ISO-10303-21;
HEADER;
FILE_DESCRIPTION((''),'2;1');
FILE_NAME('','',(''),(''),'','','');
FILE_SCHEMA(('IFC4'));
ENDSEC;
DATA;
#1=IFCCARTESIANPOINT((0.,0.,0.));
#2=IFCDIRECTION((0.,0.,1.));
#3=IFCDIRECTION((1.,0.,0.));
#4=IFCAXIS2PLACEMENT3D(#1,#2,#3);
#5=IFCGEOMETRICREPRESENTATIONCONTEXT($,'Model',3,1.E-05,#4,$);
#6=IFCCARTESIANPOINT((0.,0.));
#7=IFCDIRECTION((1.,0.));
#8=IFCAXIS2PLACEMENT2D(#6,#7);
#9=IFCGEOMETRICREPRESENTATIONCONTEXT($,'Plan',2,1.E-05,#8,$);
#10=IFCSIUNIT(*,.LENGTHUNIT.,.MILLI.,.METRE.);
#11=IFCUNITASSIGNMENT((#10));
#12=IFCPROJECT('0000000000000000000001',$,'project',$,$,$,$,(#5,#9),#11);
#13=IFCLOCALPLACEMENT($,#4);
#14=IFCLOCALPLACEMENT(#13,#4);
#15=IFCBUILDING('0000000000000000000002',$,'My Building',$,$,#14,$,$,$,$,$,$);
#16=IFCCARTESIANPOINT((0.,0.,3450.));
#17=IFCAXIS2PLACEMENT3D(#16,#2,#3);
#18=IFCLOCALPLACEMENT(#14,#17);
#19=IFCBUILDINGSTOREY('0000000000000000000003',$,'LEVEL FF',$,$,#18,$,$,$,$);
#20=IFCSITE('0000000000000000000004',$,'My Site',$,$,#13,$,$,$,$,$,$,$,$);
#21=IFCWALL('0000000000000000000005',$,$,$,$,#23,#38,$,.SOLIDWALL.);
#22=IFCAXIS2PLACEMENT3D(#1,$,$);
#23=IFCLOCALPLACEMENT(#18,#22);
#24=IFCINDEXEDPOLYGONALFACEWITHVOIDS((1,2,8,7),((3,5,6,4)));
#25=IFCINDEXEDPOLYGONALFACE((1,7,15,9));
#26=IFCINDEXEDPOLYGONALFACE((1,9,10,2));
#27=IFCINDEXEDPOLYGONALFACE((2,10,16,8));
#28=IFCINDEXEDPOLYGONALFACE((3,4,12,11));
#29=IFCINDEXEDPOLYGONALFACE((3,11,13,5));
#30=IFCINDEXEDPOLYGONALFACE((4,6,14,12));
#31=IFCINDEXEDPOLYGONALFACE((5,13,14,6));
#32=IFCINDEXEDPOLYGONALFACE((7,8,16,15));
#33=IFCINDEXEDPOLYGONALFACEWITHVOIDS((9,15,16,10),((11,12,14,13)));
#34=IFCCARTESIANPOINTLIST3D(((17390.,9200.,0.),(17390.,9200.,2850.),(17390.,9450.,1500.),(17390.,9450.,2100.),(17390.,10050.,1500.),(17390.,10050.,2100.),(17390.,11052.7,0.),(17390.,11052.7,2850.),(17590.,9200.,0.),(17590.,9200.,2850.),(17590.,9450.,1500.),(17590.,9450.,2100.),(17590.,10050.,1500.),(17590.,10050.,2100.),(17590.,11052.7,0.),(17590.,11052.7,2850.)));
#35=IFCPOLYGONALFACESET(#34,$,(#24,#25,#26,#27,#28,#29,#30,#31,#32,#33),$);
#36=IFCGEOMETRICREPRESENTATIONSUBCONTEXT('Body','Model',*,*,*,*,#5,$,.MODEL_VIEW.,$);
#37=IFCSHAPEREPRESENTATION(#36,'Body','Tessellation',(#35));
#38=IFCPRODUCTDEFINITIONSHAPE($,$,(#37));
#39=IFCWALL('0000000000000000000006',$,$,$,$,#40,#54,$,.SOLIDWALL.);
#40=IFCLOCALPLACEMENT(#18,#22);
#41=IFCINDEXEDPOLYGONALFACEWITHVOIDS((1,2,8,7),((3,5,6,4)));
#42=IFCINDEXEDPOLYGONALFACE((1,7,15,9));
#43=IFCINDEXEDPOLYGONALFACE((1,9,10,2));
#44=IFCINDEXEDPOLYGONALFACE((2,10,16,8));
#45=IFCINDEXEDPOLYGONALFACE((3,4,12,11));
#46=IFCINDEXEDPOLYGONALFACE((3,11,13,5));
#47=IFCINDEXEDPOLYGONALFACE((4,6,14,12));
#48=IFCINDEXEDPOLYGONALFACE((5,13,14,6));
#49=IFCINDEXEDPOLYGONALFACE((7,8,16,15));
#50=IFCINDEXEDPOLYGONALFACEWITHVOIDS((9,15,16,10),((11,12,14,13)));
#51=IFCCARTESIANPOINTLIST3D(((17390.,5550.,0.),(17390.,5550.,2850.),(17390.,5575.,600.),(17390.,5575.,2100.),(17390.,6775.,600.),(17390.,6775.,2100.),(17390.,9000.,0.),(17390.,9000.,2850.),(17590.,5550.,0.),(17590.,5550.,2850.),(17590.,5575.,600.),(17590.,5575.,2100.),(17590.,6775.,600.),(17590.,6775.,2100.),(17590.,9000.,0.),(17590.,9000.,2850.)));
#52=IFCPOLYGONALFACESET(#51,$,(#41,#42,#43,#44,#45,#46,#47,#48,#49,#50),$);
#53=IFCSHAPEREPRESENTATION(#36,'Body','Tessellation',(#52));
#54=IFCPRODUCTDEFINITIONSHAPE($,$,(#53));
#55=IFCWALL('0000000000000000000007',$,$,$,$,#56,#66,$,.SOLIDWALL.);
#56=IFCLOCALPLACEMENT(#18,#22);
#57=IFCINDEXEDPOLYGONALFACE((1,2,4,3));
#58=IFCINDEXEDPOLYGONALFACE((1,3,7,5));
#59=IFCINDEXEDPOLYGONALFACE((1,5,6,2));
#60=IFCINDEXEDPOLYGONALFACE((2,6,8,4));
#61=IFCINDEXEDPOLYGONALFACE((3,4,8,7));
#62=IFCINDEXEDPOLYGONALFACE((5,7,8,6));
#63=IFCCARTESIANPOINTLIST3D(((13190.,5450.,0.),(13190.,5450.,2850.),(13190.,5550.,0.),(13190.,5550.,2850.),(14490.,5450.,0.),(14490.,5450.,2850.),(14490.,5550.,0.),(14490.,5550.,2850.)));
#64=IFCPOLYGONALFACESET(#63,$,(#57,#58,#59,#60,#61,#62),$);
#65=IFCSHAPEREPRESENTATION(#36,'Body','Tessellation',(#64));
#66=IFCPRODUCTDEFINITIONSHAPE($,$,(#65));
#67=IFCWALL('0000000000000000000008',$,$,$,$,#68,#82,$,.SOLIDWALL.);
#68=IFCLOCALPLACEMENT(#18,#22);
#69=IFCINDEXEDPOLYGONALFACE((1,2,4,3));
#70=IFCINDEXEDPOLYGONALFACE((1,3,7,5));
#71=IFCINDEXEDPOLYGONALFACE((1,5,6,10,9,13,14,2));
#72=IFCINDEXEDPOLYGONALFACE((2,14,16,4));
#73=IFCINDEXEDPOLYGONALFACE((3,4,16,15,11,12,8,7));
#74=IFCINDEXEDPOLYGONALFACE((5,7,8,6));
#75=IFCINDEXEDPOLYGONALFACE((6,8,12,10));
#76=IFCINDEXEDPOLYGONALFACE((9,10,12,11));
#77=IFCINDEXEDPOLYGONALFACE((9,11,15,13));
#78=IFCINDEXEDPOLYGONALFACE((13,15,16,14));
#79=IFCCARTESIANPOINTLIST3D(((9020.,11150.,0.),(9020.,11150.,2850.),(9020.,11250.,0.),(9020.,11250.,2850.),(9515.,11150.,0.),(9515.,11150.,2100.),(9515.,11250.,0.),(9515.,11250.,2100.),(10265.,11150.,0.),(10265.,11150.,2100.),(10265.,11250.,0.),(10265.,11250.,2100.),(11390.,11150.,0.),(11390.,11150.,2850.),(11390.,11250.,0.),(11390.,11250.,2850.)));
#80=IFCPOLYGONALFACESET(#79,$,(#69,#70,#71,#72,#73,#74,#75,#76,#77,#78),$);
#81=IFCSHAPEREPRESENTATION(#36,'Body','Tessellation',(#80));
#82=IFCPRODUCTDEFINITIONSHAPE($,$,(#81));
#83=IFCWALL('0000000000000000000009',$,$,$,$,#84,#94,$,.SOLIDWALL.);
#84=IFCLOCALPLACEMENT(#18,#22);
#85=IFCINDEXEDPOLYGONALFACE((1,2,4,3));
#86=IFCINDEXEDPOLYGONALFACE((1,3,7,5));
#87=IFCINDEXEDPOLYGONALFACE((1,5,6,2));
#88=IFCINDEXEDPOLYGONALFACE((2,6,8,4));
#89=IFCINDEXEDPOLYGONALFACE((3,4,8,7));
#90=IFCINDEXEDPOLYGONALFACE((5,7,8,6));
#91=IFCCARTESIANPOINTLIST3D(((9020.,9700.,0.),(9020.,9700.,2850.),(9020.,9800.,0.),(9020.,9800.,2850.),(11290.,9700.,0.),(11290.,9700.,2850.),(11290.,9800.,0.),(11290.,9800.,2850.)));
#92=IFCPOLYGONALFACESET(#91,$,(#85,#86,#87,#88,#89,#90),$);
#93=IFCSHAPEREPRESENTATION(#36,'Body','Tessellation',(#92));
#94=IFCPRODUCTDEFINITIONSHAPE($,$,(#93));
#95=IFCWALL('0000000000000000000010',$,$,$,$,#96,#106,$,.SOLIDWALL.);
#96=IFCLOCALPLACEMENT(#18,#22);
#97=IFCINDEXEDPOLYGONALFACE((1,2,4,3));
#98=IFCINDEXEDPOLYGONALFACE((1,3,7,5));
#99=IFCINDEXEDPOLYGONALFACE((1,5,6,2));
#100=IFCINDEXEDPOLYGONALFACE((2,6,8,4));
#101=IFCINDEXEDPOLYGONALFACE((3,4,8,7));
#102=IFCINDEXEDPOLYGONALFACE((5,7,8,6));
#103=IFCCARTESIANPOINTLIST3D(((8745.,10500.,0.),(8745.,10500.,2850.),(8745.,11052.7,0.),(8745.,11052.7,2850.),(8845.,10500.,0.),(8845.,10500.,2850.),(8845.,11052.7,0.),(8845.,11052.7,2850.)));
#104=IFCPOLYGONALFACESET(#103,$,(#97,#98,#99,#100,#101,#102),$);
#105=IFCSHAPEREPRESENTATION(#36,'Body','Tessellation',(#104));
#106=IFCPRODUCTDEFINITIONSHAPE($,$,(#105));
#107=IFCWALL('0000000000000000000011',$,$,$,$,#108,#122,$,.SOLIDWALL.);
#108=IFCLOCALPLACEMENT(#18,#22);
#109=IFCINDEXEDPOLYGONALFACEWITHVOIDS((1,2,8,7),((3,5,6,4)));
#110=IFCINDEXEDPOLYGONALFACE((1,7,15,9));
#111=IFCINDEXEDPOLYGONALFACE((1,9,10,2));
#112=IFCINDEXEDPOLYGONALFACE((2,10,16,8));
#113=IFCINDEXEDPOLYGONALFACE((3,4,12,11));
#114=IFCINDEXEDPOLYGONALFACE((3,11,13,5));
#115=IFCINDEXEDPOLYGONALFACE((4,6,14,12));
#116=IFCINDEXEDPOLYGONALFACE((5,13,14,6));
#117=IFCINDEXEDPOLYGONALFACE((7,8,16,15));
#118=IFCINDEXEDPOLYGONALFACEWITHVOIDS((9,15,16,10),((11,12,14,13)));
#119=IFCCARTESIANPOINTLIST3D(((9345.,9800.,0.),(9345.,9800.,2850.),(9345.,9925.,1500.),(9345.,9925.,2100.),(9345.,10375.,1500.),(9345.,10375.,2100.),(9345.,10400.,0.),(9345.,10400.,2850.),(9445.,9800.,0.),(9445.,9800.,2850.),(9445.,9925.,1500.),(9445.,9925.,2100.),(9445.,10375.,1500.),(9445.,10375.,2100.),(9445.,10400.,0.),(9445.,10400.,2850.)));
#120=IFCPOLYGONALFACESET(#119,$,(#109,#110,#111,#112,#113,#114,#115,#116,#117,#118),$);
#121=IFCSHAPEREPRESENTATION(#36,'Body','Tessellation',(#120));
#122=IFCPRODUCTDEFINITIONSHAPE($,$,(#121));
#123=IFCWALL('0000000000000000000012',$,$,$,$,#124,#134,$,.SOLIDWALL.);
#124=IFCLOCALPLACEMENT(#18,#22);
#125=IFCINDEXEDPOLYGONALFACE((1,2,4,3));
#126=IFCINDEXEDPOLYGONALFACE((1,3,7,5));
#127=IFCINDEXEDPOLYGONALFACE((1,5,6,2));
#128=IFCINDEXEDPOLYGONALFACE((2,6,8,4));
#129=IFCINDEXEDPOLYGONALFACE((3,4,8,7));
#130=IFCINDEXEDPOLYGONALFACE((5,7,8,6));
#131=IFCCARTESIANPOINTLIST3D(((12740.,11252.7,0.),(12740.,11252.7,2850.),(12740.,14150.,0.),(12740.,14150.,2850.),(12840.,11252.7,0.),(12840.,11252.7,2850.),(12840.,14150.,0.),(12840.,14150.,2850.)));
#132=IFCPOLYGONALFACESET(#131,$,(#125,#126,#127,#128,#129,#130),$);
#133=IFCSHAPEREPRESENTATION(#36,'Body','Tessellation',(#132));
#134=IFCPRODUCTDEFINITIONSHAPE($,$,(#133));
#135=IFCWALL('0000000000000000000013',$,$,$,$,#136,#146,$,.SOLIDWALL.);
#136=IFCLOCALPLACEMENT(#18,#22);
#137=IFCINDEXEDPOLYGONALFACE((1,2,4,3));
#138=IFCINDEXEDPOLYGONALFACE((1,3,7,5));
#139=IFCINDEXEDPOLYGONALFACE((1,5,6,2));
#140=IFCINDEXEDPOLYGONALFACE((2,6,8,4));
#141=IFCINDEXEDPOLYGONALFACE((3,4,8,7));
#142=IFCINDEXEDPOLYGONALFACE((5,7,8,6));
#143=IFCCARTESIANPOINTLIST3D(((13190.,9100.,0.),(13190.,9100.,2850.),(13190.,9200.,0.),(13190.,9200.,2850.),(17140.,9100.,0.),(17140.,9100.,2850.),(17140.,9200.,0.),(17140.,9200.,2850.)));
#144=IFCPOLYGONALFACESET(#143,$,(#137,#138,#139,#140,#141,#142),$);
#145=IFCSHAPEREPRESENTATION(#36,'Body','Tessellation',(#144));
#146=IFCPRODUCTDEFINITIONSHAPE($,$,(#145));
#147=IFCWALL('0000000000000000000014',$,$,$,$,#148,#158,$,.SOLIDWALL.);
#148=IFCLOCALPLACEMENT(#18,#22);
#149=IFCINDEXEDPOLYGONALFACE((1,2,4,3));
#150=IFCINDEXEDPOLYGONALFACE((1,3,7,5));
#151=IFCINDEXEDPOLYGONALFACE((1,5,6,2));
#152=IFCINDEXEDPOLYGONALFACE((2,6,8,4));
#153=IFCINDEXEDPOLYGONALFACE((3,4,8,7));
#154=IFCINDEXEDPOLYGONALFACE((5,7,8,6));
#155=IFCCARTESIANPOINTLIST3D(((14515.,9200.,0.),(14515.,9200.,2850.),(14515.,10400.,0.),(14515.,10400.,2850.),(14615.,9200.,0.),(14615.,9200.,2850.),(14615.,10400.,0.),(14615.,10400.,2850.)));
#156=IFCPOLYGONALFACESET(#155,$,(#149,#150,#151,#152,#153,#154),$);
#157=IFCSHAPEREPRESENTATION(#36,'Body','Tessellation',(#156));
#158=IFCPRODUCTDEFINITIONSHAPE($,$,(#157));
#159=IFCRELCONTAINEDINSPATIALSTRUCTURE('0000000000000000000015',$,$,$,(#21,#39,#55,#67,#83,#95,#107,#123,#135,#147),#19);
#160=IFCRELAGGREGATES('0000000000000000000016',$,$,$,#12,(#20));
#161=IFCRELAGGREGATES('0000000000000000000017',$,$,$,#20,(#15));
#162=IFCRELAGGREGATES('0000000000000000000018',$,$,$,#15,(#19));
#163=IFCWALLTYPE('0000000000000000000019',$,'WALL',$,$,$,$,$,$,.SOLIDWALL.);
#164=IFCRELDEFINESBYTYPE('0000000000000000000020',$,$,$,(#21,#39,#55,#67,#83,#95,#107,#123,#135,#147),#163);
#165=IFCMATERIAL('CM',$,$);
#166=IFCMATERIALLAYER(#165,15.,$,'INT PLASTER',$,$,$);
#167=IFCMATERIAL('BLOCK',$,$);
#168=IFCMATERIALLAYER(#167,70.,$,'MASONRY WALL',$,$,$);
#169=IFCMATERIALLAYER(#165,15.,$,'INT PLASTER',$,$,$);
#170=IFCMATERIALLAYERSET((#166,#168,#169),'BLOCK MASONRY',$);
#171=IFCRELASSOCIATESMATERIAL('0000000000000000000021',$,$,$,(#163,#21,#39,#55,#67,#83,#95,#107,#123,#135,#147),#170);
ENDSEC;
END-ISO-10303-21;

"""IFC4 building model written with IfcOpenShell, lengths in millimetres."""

from ifc_helpers import new_model, si_unit, frame, origin_with_axes, origin_2d_with_axis, place, context, subcontext, project, spatial, indexed_curve, outline, extrude, material, layer, layer_set, layer_usage, type_object, element, save


model = new_model("IFC4")

# Units and contexts
model_context = context("Model", 3, precision=1e-05, world=origin_with_axes())
plan_context = context("Plan", 2, precision=1e-05, world=origin_2d_with_axis())
body_context = subcontext(model_context, "Body", "Model", "MODEL_VIEW")
ifc_project = project(units=[si_unit("LENGTHUNIT", "METRE", prefix="MILLI")], contexts=[model_context, plan_context])

# Site, building, storey
site_placement = place(None, origin_with_axes())
site = spatial("IfcSite", under=ifc_project, at=site_placement, Name="My Site")
building_placement = place(site_placement, origin_with_axes())
building = spatial("IfcBuilding", under=site, at=building_placement, Name="My Building")
storey_placement = place(building_placement, frame((0.0, 0.0, 3450.0), z_axis=(0.0, 0.0, 1.0), x_axis=(1.0, 0.0, 0.0)))
storey = spatial("IfcBuildingStorey", under=building, at=storey_placement, Name="LEVEL FF")

# Shared definitions
ifc_material_1 = material(Name="CM")
ifc_layer_1 = layer(ifc_material_1, 15.0, Name="INT PLASTER")
ifc_material_2 = material(Name="BLOCK")
ifc_layer_2 = layer(ifc_material_2, 70.0, Name="MASONRY WALL")
ifc_layer_3 = layer(ifc_material_1, 15.0, Name="INT PLASTER")
ifc_layer_set = layer_set([ifc_layer_1, ifc_layer_2, ifc_layer_3], Name="BLOCK MASONRY")
wall_type = type_object("IfcWallType", Name="WALL", PredefinedType="SOLIDWALL", material=ifc_layer_set)

# Walls, openings
ifc_layer_usage_1 = layer_usage(ifc_layer_set, "AXIS2", "POSITIVE", 0.0)
wall_1_placement = place(storey_placement, frame((17590.0, 9200.0, 0.0), z_axis=(0.0, 0.0, 1.0), x_axis=(0.0, 1.0, 0.0)))
wall_1 = element("IfcWall", 1, at=wall_1_placement, inside=storey, type_object=wall_type, material=ifc_layer_usage_1, PredefinedType="SOLIDWALL", context=body_context, shape_type="SweptSolid", body=[
    extrude(outline(indexed_curve([(0.0, 0.0), (0.0, 200.0), (1852.7, 200.0), (1852.7, 0.0), (0.0, 0.0)], self_intersect=False)), origin_with_axes(), (0.0, 0.0, 1.0), 2850.0),
])
opening_1_placement = place(wall_1_placement, frame((850.0, 200.0, 1500.0), z_axis=(0.0, 0.0, 1.0), x_axis=(-1.0, 0.0, 0.0)))
element("IfcOpeningElement", 2, at=opening_1_placement, cuts=wall_1, PredefinedType="OPENING", context=body_context, shape_type="SweptSolid", body=[
    extrude(outline(indexed_curve([(0.0, 0.0), (0.0, 400.0), (600.0, 400.0), (600.0, 0.0), (0.0, 0.0)], self_intersect=False)), frame((0.0, -100.0, 0.0), z_axis=(0.0, 0.0, 1.0), x_axis=(1.0, 0.0, 0.0)), (0.0, 0.0, 1.0), 600.0),
])
ifc_layer_usage_2 = layer_usage(ifc_layer_set, "AXIS2", "POSITIVE", 0.0)
wall_2_placement = place(storey_placement, frame((17590.0, 5550.0, 0.0), z_axis=(0.0, 0.0, 1.0), x_axis=(0.0, 1.0, 0.0)))
wall_2 = element("IfcWall", 3, at=wall_2_placement, inside=storey, type_object=wall_type, material=ifc_layer_usage_2, PredefinedType="SOLIDWALL", context=body_context, shape_type="SweptSolid", body=[
    extrude(outline(indexed_curve([(0.0, 0.0), (0.0, 200.0), (3450.0, 200.0), (3450.0, 0.0), (0.0, 0.0)], self_intersect=False)), origin_with_axes(), (0.0, 0.0, 1.0), 2850.0),
])
opening_2_placement = place(wall_2_placement, frame((1225.0, 200.0, 600.0), z_axis=(0.0, 0.0, 1.0), x_axis=(-1.0, 0.0, 0.0)))
element("IfcOpeningElement", 4, at=opening_2_placement, cuts=wall_2, PredefinedType="OPENING", context=body_context, shape_type="SweptSolid", body=[
    extrude(outline(indexed_curve([(0.0, 0.0), (0.0, 400.0), (1200.0, 400.0), (1200.0, 0.0), (0.0, 0.0)], self_intersect=False)), frame((0.0, -100.0, 0.0), z_axis=(0.0, 0.0, 1.0), x_axis=(1.0, 0.0, 0.0)), (0.0, 0.0, 1.0), 1500.0),
])

# Wall
ifc_layer_usage_3 = layer_usage(ifc_layer_set, "AXIS2", "POSITIVE", 0.0)
wall_3_placement = place(storey_placement, frame((13190.0, 5550.0, 0.0), z_axis=(0.0, 0.0, 1.0), x_axis=(0.0, -1.0, 0.0)))
element("IfcWall", 5, at=wall_3_placement, inside=storey, type_object=wall_type, material=ifc_layer_usage_3, PredefinedType="SOLIDWALL", context=body_context, shape_type="SweptSolid", body=[
    extrude(outline(indexed_curve([(0.0, 0.0), (0.0, 1300.0), (100.0, 1300.0), (100.0, 0.0), (0.0, 0.0)], self_intersect=False)), origin_with_axes(), (0.0, 0.0, 1.0), 2850.0),
])

# Wall, opening
ifc_layer_usage_4 = layer_usage(ifc_layer_set, "AXIS2", "POSITIVE", 0.0)
wall_4_placement = place(storey_placement, frame((9020.0, 11250.0, 0.0), z_axis=(0.0, 0.0, 1.0), x_axis=(0.0, -1.0, 0.0)))
wall_4 = element("IfcWall", 6, at=wall_4_placement, inside=storey, type_object=wall_type, material=ifc_layer_usage_4, PredefinedType="SOLIDWALL", context=body_context, shape_type="SweptSolid", body=[
    extrude(outline(indexed_curve([(0.0, 0.0), (0.0, 2370.0), (100.0, 2370.0), (100.0, 0.0), (0.0, 0.0)], self_intersect=False)), origin_with_axes(), (0.0, 0.0, 1.0), 2850.0),
])
opening_3_placement = place(wall_4_placement, frame((0.0, 1245.0, 0.0), z_axis=(0.0, 0.0, 1.0), x_axis=(0.0, -1.0, 0.0)))
element("IfcOpeningElement", 7, at=opening_3_placement, cuts=wall_4, PredefinedType="OPENING", context=body_context, shape_type="SweptSolid", body=[
    extrude(outline(indexed_curve([(0.0, 0.0), (0.0, 400.0), (750.0, 400.0), (750.0, 0.0), (0.0, 0.0)], self_intersect=False)), frame((0.0, -100.0, 0.0), z_axis=(0.0, 0.0, 1.0), x_axis=(1.0, 0.0, 0.0)), (0.0, 0.0, 1.0), 2100.0),
])

# Wall
ifc_layer_usage_5 = layer_usage(ifc_layer_set, "AXIS2", "POSITIVE", 0.0)
wall_5_placement = place(storey_placement, frame((9020.0, 9800.0, 0.0), z_axis=(0.0, 0.0, 1.0), x_axis=(0.0, -1.0, 0.0)))
element("IfcWall", 8, at=wall_5_placement, inside=storey, type_object=wall_type, material=ifc_layer_usage_5, PredefinedType="SOLIDWALL", context=body_context, shape_type="SweptSolid", body=[
    extrude(outline(indexed_curve([(0.0, 0.0), (0.0, 2270.0), (100.0, 2270.0), (100.0, 0.0), (0.0, 0.0)], self_intersect=False)), origin_with_axes(), (0.0, 0.0, 1.0), 2850.0),
])

# Wall
ifc_layer_usage_6 = layer_usage(ifc_layer_set, "AXIS2", "POSITIVE", 0.0)
wall_6_placement = place(storey_placement, frame((8845.0, 10500.0, 0.0), z_axis=(0.0, 0.0, 1.0), x_axis=(0.0, 1.0, 0.0)))
element("IfcWall", 9, at=wall_6_placement, inside=storey, type_object=wall_type, material=ifc_layer_usage_6, PredefinedType="SOLIDWALL", context=body_context, shape_type="SweptSolid", body=[
    extrude(outline(indexed_curve([(0.0, 0.0), (0.0, 100.0), (552.7, 100.0), (552.7, 0.0), (0.0, 0.0)], self_intersect=False)), origin_with_axes(), (0.0, 0.0, 1.0), 2850.0),
])

# Wall, opening
ifc_layer_usage_7 = layer_usage(ifc_layer_set, "AXIS2", "POSITIVE", 0.0)
wall_7_placement = place(storey_placement, frame((9445.0, 9800.0, 0.0), z_axis=(0.0, 0.0, 1.0), x_axis=(0.0, 1.0, 0.0)))
wall_7 = element("IfcWall", 10, at=wall_7_placement, inside=storey, type_object=wall_type, material=ifc_layer_usage_7, PredefinedType="SOLIDWALL", context=body_context, shape_type="SweptSolid", body=[
    extrude(outline(indexed_curve([(0.0, 0.0), (0.0, 100.0), (600.0, 100.0), (600.0, 0.0), (0.0, 0.0)], self_intersect=False)), origin_with_axes(), (0.0, 0.0, 1.0), 2850.0),
])
opening_4_placement = place(wall_7_placement, frame((125.0, 0.0, 1500.0), z_axis=(0.0, 0.0, 1.0), x_axis=(1.0, 0.0, 0.0)))
element("IfcOpeningElement", 11, at=opening_4_placement, cuts=wall_7, PredefinedType="OPENING", context=body_context, shape_type="SweptSolid", body=[
    extrude(outline(indexed_curve([(0.0, 0.0), (0.0, 400.0), (450.0, 400.0), (450.0, 0.0), (0.0, 0.0)], self_intersect=False)), frame((0.0, -100.0, 0.0), z_axis=(0.0, 0.0, 1.0), x_axis=(1.0, 0.0, 0.0)), (0.0, 0.0, 1.0), 600.0),
])

# Walls
ifc_layer_usage_8 = layer_usage(ifc_layer_set, "AXIS2", "POSITIVE", 0.0)
wall_8_placement = place(storey_placement, frame((12840.0, 11252.7, 0.0), z_axis=(0.0, 0.0, 1.0), x_axis=(0.0, 1.0, 0.0)))
element("IfcWall", 12, at=wall_8_placement, inside=storey, type_object=wall_type, material=ifc_layer_usage_8, PredefinedType="SOLIDWALL", context=body_context, shape_type="SweptSolid", body=[
    extrude(outline(indexed_curve([(0.0, 0.0), (0.0, 100.0), (2897.3, 100.0), (2897.3, 0.0), (0.0, 0.0)], self_intersect=False)), origin_with_axes(), (0.0, 0.0, 1.0), 2850.0),
])
ifc_layer_usage_9 = layer_usage(ifc_layer_set, "AXIS2", "POSITIVE", 0.0)
wall_9_placement = place(storey_placement, frame((13190.0, 9200.0, 0.0), z_axis=(0.0, 0.0, 1.0), x_axis=(0.0, -1.0, 0.0)))
element("IfcWall", 13, at=wall_9_placement, inside=storey, type_object=wall_type, material=ifc_layer_usage_9, PredefinedType="SOLIDWALL", context=body_context, shape_type="SweptSolid", body=[
    extrude(outline(indexed_curve([(0.0, 0.0), (0.0, 3950.0), (100.0, 3950.0), (100.0, 0.0), (0.0, 0.0)], self_intersect=False)), origin_with_axes(), (0.0, 0.0, 1.0), 2850.0),
])
ifc_layer_usage_10 = layer_usage(ifc_layer_set, "AXIS2", "POSITIVE", 0.0)
wall_10_placement = place(storey_placement, frame((14615.0, 9200.0, 0.0), z_axis=(0.0, 0.0, 1.0), x_axis=(0.0, 1.0, 0.0)))
element("IfcWall", 14, at=wall_10_placement, inside=storey, type_object=wall_type, material=ifc_layer_usage_10, PredefinedType="SOLIDWALL", context=body_context, shape_type="SweptSolid", body=[
    extrude(outline(indexed_curve([(0.0, 0.0), (0.0, 100.0), (1200.0, 100.0), (1200.0, 0.0), (0.0, 0.0)], self_intersect=False)), origin_with_axes(), (0.0, 0.0, 1.0), 2850.0),
])

save(model, "model.ifc")
